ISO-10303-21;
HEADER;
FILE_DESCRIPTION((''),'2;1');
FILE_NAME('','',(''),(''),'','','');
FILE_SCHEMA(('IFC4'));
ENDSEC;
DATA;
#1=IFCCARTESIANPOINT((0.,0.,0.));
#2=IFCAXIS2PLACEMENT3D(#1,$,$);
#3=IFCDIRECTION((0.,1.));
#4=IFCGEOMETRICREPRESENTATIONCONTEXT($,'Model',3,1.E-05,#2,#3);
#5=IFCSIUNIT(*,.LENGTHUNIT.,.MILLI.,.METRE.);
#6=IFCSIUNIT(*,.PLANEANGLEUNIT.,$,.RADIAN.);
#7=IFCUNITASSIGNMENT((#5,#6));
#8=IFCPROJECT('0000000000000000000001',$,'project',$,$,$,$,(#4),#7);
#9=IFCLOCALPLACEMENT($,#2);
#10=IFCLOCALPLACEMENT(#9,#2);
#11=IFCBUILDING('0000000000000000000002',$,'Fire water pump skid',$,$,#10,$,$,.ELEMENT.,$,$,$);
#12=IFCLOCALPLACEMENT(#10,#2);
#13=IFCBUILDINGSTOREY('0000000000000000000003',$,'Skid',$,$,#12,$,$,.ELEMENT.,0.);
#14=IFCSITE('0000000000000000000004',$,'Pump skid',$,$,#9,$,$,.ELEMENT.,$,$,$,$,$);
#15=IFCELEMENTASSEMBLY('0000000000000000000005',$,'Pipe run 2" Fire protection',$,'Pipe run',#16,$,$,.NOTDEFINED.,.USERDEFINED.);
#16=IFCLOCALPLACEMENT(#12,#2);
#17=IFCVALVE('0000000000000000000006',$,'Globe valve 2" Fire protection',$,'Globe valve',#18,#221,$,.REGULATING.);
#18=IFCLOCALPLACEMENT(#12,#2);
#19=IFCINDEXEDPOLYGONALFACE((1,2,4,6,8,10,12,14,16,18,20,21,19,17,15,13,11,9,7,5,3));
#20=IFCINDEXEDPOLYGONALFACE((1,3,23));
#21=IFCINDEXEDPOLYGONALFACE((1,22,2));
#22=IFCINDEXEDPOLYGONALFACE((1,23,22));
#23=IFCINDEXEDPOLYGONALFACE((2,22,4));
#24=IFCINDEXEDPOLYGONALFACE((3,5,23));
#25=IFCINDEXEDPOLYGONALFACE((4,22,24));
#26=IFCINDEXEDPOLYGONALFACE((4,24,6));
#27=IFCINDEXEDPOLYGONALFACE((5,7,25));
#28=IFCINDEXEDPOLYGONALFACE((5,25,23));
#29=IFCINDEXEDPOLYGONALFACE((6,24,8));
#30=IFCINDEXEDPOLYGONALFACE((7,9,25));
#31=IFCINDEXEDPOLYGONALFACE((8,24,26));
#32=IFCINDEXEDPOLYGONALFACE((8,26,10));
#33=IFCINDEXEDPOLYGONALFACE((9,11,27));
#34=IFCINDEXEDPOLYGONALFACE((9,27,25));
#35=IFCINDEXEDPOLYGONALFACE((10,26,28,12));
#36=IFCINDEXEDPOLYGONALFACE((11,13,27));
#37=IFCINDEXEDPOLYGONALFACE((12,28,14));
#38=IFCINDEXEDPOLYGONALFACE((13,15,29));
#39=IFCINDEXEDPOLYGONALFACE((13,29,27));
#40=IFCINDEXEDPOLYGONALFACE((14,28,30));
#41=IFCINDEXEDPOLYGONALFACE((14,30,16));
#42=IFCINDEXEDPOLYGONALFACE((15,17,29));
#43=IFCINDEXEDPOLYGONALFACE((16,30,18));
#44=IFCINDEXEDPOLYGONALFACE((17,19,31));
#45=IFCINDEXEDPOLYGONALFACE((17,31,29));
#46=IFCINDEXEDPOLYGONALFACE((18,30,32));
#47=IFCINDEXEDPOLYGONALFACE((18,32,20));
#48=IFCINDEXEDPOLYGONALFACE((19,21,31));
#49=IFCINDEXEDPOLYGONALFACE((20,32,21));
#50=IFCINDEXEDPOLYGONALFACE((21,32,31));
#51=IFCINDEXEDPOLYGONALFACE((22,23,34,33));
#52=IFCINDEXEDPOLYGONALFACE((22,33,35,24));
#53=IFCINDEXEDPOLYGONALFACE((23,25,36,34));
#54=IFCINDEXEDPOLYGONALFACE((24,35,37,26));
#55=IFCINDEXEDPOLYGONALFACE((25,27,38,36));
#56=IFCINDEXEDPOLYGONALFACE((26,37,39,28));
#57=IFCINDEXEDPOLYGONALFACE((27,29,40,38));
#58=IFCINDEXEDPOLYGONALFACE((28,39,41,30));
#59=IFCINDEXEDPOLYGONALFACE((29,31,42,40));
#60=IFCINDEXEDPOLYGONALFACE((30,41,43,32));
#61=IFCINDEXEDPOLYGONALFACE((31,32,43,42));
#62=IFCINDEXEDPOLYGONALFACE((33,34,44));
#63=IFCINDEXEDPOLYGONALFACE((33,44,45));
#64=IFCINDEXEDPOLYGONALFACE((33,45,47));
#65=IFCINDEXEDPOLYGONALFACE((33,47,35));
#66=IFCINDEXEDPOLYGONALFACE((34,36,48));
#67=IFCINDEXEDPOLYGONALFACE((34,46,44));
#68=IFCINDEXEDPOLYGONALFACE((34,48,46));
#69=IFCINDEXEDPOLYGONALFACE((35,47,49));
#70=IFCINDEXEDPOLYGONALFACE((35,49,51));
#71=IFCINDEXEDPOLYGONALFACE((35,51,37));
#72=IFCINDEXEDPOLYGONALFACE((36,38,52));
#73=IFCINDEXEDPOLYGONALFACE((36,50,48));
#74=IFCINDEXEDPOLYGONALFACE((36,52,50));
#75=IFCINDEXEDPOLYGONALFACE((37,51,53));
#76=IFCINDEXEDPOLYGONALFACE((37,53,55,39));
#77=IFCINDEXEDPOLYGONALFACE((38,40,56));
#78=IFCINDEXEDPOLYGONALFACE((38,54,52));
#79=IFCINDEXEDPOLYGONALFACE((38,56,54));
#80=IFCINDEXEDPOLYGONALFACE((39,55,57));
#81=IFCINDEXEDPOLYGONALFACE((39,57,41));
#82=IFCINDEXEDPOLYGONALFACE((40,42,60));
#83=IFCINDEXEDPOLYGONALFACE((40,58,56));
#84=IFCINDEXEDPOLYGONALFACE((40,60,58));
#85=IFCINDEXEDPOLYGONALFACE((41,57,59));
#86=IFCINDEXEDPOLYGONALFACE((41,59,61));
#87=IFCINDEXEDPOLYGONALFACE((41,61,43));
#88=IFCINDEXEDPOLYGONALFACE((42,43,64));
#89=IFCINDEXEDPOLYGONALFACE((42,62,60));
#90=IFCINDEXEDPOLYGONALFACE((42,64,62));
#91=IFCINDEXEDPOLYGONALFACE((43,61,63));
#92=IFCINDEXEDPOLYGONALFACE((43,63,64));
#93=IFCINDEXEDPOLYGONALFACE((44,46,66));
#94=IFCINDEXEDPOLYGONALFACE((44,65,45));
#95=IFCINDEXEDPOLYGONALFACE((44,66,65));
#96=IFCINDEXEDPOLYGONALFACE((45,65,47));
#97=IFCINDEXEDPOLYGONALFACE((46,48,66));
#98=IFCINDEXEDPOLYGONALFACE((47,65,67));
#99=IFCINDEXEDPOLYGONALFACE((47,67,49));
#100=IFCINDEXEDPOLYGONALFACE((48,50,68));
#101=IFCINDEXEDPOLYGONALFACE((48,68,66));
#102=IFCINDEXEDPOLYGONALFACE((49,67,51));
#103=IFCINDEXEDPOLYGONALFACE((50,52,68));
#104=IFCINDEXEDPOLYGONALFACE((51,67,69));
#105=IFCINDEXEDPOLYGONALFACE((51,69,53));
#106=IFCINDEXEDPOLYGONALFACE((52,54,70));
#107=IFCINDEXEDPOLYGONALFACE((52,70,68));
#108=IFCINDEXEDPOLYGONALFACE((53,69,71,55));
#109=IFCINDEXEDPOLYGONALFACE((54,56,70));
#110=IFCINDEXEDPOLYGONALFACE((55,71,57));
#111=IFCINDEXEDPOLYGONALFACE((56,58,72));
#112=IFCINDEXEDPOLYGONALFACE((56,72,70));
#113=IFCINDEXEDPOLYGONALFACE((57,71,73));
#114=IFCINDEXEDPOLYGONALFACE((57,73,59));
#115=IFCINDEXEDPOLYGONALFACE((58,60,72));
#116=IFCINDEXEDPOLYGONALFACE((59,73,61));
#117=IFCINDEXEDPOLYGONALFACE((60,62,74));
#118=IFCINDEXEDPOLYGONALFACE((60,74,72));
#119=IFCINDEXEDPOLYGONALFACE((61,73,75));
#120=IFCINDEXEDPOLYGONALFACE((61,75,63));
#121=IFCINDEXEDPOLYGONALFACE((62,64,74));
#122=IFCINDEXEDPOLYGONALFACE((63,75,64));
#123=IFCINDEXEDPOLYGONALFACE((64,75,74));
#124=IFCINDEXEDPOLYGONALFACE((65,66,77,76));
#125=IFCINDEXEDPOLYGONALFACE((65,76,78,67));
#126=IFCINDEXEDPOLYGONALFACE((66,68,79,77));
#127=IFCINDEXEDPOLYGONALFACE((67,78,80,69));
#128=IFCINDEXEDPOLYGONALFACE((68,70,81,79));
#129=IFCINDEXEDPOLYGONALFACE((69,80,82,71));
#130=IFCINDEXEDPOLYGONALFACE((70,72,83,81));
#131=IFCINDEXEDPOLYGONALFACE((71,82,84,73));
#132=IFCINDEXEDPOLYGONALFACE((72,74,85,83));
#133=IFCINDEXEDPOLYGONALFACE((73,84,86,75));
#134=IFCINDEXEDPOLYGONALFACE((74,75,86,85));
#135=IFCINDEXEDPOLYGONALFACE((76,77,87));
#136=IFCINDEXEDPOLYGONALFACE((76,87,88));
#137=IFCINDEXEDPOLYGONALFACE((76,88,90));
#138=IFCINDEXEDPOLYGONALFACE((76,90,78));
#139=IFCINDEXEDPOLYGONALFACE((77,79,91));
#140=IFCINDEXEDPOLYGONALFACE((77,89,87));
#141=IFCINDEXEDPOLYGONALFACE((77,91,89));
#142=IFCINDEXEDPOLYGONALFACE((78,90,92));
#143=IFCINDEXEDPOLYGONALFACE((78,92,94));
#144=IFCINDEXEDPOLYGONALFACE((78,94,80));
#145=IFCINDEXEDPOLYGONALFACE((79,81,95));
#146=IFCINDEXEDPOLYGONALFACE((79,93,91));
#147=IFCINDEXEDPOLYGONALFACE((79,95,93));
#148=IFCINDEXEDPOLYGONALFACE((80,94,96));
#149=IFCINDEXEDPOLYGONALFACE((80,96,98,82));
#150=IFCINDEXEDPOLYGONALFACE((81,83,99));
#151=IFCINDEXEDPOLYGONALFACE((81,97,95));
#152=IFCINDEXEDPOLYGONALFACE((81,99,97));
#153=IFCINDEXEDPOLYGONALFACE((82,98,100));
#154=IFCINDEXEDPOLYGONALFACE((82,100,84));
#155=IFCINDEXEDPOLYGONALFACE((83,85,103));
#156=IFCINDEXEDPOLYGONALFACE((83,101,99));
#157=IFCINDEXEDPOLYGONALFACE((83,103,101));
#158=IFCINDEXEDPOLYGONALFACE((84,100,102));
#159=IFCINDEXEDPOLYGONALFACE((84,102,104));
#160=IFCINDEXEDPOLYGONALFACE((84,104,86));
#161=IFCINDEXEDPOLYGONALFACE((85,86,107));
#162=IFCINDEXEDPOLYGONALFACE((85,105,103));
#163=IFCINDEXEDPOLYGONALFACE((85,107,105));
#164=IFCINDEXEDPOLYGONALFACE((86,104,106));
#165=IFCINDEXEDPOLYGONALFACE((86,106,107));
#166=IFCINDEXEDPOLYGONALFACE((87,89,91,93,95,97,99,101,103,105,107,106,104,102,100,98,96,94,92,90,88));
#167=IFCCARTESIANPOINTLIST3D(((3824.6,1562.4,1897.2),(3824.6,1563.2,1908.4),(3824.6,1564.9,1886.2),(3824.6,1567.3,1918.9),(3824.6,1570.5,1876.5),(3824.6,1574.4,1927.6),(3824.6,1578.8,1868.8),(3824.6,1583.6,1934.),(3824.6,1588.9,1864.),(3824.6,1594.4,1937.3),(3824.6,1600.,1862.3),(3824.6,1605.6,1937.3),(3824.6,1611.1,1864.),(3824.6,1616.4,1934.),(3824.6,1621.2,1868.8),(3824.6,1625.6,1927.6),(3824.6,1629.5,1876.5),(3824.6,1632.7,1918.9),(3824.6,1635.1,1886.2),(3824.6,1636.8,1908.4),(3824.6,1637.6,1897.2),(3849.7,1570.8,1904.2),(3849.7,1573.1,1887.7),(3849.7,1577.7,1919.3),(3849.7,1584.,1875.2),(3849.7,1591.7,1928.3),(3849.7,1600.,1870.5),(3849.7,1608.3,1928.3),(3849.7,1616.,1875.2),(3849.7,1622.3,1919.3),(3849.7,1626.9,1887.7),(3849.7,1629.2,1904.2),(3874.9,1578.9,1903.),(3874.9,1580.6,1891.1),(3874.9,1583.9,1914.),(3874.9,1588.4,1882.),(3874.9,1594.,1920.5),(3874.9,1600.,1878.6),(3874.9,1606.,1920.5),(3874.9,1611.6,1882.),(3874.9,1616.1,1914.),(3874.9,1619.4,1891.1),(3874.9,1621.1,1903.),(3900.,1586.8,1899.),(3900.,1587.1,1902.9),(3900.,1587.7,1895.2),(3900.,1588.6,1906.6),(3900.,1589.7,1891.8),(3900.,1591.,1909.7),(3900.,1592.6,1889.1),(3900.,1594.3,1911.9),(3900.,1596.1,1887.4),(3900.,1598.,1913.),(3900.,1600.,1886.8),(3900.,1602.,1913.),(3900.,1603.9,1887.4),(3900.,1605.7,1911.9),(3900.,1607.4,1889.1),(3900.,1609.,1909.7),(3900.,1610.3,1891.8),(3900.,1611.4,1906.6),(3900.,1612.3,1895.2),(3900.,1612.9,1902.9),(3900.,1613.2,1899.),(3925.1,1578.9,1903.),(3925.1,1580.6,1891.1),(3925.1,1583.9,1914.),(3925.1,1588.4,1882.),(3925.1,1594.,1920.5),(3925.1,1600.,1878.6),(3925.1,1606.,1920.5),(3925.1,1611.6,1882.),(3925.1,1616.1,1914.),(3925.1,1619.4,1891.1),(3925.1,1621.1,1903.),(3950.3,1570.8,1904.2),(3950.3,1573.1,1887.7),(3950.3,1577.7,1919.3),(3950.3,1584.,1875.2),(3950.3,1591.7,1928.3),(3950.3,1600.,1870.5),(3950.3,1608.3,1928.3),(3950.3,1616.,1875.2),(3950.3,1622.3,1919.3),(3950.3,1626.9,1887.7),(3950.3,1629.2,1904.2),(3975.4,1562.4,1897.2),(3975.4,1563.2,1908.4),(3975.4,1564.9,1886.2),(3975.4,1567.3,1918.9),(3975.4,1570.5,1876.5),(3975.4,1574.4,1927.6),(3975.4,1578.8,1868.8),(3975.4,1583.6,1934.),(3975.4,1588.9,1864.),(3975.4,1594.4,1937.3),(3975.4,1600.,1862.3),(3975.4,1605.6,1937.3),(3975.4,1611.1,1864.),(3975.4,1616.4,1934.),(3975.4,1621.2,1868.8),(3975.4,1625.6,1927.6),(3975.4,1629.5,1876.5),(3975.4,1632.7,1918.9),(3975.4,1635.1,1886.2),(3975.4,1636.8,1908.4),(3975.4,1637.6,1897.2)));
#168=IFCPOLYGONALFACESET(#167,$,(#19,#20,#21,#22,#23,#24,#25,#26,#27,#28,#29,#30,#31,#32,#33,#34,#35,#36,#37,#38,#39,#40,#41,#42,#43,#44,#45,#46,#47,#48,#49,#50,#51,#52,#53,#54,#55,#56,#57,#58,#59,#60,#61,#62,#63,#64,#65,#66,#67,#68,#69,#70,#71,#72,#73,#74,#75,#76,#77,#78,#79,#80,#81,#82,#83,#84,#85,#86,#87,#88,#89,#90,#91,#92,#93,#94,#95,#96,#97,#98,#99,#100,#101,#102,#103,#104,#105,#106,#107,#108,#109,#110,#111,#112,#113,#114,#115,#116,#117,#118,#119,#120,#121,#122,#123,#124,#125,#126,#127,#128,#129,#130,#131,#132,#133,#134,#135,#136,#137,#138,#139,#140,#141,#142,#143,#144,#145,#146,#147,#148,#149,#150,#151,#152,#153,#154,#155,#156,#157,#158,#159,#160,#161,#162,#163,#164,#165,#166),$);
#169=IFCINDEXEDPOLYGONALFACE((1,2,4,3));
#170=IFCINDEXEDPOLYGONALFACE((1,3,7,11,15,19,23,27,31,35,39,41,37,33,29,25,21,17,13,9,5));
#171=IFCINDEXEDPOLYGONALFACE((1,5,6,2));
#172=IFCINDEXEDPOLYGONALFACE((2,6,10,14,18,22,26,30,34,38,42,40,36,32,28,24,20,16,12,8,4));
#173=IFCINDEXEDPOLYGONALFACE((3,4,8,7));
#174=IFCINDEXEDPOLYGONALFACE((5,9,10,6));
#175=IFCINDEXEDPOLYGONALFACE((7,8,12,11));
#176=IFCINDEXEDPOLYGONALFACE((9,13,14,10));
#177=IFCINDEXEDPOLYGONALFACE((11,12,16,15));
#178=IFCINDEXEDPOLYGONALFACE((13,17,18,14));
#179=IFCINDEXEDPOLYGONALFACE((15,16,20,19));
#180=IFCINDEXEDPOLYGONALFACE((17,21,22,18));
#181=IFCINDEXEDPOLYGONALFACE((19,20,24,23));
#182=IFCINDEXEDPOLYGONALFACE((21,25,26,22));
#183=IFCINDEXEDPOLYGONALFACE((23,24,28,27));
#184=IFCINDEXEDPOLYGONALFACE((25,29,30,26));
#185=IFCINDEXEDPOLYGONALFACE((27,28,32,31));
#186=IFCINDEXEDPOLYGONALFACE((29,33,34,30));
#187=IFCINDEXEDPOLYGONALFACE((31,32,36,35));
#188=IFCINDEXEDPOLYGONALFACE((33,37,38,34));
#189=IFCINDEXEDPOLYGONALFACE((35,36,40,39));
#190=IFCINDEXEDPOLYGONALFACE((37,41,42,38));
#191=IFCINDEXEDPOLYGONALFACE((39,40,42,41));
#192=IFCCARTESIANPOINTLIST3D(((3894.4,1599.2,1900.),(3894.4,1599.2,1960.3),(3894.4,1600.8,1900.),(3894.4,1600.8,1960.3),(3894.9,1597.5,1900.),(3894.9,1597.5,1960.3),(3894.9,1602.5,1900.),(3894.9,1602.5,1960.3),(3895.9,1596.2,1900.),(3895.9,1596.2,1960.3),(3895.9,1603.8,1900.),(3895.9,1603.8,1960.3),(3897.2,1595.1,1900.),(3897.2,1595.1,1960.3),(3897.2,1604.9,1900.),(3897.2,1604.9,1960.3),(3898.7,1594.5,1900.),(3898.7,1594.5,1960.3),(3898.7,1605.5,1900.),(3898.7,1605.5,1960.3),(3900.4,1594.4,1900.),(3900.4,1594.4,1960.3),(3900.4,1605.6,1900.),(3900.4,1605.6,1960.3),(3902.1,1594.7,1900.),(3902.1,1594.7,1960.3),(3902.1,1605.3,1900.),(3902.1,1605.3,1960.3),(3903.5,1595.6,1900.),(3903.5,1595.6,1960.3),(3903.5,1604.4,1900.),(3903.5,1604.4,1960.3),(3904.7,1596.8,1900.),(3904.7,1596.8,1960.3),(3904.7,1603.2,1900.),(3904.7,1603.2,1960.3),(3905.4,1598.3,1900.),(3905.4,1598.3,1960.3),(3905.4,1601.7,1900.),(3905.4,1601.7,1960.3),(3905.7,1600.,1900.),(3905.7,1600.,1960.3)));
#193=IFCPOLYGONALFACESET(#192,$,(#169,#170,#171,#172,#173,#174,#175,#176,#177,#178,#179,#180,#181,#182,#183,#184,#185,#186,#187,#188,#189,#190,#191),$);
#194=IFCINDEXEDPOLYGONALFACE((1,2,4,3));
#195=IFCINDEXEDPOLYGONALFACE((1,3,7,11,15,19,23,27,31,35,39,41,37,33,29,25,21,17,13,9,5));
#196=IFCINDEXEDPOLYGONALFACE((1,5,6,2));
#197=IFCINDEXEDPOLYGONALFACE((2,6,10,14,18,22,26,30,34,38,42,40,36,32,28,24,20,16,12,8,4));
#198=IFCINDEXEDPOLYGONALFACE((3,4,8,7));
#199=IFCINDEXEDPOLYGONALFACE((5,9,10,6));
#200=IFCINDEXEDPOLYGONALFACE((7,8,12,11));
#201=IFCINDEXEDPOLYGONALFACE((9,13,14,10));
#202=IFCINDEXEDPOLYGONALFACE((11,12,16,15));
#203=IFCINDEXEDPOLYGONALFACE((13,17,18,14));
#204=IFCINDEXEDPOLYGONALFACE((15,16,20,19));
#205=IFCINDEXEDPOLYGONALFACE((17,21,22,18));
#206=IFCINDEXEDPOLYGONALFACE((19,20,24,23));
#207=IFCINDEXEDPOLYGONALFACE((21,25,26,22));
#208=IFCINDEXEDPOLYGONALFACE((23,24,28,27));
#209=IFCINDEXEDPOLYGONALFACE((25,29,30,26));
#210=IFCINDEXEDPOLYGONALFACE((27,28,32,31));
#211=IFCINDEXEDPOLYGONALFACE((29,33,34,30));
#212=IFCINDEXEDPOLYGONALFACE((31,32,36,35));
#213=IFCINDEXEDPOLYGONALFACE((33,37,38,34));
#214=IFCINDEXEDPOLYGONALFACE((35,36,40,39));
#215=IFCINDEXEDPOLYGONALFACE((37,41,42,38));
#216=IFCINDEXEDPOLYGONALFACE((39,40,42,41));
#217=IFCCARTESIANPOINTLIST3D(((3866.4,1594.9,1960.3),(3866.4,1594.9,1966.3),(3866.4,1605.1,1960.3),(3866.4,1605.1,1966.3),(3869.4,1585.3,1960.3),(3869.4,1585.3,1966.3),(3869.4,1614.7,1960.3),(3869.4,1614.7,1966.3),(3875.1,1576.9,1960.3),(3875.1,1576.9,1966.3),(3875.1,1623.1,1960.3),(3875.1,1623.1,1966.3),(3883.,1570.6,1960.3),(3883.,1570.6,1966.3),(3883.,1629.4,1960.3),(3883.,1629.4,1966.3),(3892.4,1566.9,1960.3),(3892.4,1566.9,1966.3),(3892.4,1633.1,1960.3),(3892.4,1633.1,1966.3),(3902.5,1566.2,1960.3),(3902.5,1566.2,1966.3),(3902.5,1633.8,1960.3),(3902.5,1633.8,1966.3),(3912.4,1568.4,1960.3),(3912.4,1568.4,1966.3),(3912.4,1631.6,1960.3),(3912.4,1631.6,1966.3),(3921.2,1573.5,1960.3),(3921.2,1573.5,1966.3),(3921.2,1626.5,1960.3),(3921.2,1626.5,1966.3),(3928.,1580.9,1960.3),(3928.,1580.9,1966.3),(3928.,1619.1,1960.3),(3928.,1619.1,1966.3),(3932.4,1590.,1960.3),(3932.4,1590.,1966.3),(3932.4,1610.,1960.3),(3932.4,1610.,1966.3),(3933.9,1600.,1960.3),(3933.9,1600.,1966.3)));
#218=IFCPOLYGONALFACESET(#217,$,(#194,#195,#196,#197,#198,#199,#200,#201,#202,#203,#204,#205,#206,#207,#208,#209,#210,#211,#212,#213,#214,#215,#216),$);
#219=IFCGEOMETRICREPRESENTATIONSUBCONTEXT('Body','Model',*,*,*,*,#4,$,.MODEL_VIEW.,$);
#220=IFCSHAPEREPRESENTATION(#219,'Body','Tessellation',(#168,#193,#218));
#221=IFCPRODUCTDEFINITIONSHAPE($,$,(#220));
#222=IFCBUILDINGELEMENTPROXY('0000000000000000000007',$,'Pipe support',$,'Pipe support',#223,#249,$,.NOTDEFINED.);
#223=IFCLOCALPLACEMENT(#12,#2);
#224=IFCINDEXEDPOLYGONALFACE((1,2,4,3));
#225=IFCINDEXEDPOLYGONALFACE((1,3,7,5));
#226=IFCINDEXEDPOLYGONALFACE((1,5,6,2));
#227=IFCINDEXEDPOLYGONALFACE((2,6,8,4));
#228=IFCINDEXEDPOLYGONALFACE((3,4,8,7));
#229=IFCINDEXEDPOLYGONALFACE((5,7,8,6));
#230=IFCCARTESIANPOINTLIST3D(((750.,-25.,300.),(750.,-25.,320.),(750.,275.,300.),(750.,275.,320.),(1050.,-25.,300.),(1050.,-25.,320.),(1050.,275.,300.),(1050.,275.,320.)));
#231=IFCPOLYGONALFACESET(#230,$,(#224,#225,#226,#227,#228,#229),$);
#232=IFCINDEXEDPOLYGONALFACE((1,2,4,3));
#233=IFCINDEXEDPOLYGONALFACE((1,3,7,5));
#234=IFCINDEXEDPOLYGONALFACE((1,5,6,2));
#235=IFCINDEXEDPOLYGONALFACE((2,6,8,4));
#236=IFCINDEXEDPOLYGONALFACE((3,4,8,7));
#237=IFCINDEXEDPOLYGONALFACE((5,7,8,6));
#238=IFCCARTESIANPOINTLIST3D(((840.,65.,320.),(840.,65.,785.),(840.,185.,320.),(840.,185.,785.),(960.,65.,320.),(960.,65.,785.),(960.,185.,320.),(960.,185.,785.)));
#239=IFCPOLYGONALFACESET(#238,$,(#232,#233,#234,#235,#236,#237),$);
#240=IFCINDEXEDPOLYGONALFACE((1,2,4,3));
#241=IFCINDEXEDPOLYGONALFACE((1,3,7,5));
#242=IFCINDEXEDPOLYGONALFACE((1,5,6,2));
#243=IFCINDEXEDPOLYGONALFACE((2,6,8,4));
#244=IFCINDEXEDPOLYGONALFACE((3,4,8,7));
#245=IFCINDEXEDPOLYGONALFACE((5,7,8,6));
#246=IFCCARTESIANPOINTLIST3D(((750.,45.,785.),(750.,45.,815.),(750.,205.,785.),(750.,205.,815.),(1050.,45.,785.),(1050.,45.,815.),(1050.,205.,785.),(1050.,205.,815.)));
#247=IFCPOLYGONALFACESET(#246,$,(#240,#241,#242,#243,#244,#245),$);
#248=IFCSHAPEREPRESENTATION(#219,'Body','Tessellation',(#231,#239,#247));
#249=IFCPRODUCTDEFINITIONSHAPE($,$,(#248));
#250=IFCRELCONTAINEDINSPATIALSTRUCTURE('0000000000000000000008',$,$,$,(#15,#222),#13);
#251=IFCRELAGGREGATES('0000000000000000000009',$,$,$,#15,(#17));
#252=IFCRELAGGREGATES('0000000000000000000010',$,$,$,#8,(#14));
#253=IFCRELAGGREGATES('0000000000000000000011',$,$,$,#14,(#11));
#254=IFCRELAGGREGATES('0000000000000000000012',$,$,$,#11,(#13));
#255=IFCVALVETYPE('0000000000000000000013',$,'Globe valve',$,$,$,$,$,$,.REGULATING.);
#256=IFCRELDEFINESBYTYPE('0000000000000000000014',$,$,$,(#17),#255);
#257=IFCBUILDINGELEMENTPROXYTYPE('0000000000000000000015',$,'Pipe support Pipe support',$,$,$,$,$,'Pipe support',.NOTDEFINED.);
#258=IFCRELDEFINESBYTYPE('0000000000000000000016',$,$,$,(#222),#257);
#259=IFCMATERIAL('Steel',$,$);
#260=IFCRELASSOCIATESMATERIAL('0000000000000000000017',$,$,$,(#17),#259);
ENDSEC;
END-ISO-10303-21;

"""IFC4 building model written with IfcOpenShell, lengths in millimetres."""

from ifc_helpers import new_model, entity, si_unit, direction, frame, origin, origin_with_axes, origin_2d, place, context, subcontext, project, spatial, polyline, circle, outline, extrude, source, transform, mapped, material, type_object, type_shapes, element, aggregate, save


model = new_model("IFC4")

# Units and contexts
model_context = context("Model", 3, precision=1e-05, world=origin(), true_north=direction((0.0, 1.0)))
body_context = subcontext(model_context, "Body", "Model", "MODEL_VIEW")
ifc_project = project(units=[si_unit("LENGTHUNIT", "METRE", prefix="MILLI"), si_unit("PLANEANGLEUNIT", "RADIAN")], contexts=[model_context])

# Site, building, storey
site_placement = place(None, origin())
site = spatial("IfcSite", under=ifc_project, at=site_placement, Name="Pump skid", CompositionType="ELEMENT")
building_placement = place(site_placement, origin())
building = spatial("IfcBuilding", under=site, at=building_placement, Name="Fire water pump skid", CompositionType="ELEMENT")
storey_placement = place(building_placement, origin())
storey = spatial("IfcBuildingStorey", under=building, at=storey_placement, Name="Skid", CompositionType="ELEMENT", Elevation=0.0)

# Element assembly
ifc_material = material(Name="Steel")
assembly_1_placement = place(storey_placement, origin_with_axes())
assembly_1 = element("IfcElementAssembly", 1, at=assembly_1_placement, inside=storey, Name="Pipe run 2\" Fire protection", ObjectType="Pipe run", AssemblyPlace="NOTDEFINED", PredefinedType="USERDEFINED")

# Valve
valve_type_1 = type_object("IfcValveType", Name="Globe valve", PredefinedType="REGULATING")
valve_1_placement = place(storey_placement, origin_with_axes())
cartesian_point_1 = entity("IfcCartesianPoint", [0.0, 0.0])
valve_1 = element("IfcValve", 2, at=valve_1_placement, type_object=valve_type_1, material=ifc_material, Name="Globe valve 2\" Fire protection", ObjectType="Globe valve", PredefinedType="REGULATING", context=body_context, shape_type="SweptSolid", body=[
    entity("IfcRevolvedAreaSolid", entity("IfcArbitraryClosedProfileDef", "AREA", None, entity("IfcPolyline", [cartesian_point_1, entity("IfcCartesianPoint", [0.0, 37.7]), entity("IfcCartesianPoint", [75.4, 13.2]), entity("IfcCartesianPoint", [150.8, 37.7]), entity("IfcCartesianPoint", [150.8, 0.0]), cartesian_point_1])), entity("IfcAxis2Placement3D", entity("IfcCartesianPoint", [3975.4, 1600.0, 1900.0]), entity("IfcDirection", [0.0, -1.0, 0.0]), entity("IfcDirection", [-1.0, 0.0, 0.0])), entity("IfcAxis1Placement", entity("IfcCartesianPoint", [0.0, 0.0, 0.0]), entity("IfcDirection", [1.0, 0.0, 0.0])), 6.283185),
    extrude(circle(Radius=5.7, at=origin_2d()), frame((3900.0, 1600.0, 1900.0), z_axis=(0.0, 0.0, 1.0), x_axis=(1.0, 0.0, 0.0)), (0.0, 0.0, 1.0), 60.3),
    extrude(circle(Radius=33.9, at=origin_2d()), frame((3900.0, 1600.0, 1960.3), z_axis=(0.0, 0.0, 1.0), x_axis=(1.0, 0.0, 0.0)), (0.0, 0.0, 1.0), 6.0),
])
aggregate(assembly_1, [valve_1])

# Building element proxy
building_element_proxy_type_1 = type_object("IfcBuildingElementProxyType", Name="Pipe support Pipe support", ElementType="Pipe support", PredefinedType="NOTDEFINED")
shared_shape_1 = source(origin(), body_context, "Body", "SweptSolid", [
    extrude(outline(polyline([(-150.0, -150.0), (150.0, -150.0), (150.0, 150.0), (-150.0, 150.0), (-150.0, -150.0)])), frame((0.0, 0.0, 300.0)), (0.0, 0.0, 1.0), 20.0),
    extrude(outline(polyline([(-60.0, -60.0), (60.0, -60.0), (60.0, 60.0), (-60.0, 60.0), (-60.0, -60.0)])), frame((0.0, 0.0, 320.0)), (0.0, 0.0, 1.0), 465.0),
    extrude(outline(polyline([(-150.0, -80.0), (150.0, -80.0), (150.0, 80.0), (-150.0, 80.0), (-150.0, -80.0)])), frame((0.0, 0.0, 785.0)), (0.0, 0.0, 1.0), 30.0),
])
type_shapes(building_element_proxy_type_1, [shared_shape_1])
for number, where, z_axis, x_axis, name in (
    (3, (900.0, 125.0, 0.0), (0.0, 0.0, 1.0), (1.0, 0.0, 0.0), "Pipe support"),
):
    element("IfcBuildingElementProxy", number, at=place(storey_placement, frame(where, z_axis=z_axis, x_axis=x_axis)), inside=storey, type_object=building_element_proxy_type_1, Name=name, ObjectType="Pipe support", PredefinedType="NOTDEFINED", context=body_context, shape_type="MappedRepresentation", body=[
        mapped(shared_shape_1, transform((0.0, 0.0, 0.0))),
    ])

save(model, "model.ifc")
